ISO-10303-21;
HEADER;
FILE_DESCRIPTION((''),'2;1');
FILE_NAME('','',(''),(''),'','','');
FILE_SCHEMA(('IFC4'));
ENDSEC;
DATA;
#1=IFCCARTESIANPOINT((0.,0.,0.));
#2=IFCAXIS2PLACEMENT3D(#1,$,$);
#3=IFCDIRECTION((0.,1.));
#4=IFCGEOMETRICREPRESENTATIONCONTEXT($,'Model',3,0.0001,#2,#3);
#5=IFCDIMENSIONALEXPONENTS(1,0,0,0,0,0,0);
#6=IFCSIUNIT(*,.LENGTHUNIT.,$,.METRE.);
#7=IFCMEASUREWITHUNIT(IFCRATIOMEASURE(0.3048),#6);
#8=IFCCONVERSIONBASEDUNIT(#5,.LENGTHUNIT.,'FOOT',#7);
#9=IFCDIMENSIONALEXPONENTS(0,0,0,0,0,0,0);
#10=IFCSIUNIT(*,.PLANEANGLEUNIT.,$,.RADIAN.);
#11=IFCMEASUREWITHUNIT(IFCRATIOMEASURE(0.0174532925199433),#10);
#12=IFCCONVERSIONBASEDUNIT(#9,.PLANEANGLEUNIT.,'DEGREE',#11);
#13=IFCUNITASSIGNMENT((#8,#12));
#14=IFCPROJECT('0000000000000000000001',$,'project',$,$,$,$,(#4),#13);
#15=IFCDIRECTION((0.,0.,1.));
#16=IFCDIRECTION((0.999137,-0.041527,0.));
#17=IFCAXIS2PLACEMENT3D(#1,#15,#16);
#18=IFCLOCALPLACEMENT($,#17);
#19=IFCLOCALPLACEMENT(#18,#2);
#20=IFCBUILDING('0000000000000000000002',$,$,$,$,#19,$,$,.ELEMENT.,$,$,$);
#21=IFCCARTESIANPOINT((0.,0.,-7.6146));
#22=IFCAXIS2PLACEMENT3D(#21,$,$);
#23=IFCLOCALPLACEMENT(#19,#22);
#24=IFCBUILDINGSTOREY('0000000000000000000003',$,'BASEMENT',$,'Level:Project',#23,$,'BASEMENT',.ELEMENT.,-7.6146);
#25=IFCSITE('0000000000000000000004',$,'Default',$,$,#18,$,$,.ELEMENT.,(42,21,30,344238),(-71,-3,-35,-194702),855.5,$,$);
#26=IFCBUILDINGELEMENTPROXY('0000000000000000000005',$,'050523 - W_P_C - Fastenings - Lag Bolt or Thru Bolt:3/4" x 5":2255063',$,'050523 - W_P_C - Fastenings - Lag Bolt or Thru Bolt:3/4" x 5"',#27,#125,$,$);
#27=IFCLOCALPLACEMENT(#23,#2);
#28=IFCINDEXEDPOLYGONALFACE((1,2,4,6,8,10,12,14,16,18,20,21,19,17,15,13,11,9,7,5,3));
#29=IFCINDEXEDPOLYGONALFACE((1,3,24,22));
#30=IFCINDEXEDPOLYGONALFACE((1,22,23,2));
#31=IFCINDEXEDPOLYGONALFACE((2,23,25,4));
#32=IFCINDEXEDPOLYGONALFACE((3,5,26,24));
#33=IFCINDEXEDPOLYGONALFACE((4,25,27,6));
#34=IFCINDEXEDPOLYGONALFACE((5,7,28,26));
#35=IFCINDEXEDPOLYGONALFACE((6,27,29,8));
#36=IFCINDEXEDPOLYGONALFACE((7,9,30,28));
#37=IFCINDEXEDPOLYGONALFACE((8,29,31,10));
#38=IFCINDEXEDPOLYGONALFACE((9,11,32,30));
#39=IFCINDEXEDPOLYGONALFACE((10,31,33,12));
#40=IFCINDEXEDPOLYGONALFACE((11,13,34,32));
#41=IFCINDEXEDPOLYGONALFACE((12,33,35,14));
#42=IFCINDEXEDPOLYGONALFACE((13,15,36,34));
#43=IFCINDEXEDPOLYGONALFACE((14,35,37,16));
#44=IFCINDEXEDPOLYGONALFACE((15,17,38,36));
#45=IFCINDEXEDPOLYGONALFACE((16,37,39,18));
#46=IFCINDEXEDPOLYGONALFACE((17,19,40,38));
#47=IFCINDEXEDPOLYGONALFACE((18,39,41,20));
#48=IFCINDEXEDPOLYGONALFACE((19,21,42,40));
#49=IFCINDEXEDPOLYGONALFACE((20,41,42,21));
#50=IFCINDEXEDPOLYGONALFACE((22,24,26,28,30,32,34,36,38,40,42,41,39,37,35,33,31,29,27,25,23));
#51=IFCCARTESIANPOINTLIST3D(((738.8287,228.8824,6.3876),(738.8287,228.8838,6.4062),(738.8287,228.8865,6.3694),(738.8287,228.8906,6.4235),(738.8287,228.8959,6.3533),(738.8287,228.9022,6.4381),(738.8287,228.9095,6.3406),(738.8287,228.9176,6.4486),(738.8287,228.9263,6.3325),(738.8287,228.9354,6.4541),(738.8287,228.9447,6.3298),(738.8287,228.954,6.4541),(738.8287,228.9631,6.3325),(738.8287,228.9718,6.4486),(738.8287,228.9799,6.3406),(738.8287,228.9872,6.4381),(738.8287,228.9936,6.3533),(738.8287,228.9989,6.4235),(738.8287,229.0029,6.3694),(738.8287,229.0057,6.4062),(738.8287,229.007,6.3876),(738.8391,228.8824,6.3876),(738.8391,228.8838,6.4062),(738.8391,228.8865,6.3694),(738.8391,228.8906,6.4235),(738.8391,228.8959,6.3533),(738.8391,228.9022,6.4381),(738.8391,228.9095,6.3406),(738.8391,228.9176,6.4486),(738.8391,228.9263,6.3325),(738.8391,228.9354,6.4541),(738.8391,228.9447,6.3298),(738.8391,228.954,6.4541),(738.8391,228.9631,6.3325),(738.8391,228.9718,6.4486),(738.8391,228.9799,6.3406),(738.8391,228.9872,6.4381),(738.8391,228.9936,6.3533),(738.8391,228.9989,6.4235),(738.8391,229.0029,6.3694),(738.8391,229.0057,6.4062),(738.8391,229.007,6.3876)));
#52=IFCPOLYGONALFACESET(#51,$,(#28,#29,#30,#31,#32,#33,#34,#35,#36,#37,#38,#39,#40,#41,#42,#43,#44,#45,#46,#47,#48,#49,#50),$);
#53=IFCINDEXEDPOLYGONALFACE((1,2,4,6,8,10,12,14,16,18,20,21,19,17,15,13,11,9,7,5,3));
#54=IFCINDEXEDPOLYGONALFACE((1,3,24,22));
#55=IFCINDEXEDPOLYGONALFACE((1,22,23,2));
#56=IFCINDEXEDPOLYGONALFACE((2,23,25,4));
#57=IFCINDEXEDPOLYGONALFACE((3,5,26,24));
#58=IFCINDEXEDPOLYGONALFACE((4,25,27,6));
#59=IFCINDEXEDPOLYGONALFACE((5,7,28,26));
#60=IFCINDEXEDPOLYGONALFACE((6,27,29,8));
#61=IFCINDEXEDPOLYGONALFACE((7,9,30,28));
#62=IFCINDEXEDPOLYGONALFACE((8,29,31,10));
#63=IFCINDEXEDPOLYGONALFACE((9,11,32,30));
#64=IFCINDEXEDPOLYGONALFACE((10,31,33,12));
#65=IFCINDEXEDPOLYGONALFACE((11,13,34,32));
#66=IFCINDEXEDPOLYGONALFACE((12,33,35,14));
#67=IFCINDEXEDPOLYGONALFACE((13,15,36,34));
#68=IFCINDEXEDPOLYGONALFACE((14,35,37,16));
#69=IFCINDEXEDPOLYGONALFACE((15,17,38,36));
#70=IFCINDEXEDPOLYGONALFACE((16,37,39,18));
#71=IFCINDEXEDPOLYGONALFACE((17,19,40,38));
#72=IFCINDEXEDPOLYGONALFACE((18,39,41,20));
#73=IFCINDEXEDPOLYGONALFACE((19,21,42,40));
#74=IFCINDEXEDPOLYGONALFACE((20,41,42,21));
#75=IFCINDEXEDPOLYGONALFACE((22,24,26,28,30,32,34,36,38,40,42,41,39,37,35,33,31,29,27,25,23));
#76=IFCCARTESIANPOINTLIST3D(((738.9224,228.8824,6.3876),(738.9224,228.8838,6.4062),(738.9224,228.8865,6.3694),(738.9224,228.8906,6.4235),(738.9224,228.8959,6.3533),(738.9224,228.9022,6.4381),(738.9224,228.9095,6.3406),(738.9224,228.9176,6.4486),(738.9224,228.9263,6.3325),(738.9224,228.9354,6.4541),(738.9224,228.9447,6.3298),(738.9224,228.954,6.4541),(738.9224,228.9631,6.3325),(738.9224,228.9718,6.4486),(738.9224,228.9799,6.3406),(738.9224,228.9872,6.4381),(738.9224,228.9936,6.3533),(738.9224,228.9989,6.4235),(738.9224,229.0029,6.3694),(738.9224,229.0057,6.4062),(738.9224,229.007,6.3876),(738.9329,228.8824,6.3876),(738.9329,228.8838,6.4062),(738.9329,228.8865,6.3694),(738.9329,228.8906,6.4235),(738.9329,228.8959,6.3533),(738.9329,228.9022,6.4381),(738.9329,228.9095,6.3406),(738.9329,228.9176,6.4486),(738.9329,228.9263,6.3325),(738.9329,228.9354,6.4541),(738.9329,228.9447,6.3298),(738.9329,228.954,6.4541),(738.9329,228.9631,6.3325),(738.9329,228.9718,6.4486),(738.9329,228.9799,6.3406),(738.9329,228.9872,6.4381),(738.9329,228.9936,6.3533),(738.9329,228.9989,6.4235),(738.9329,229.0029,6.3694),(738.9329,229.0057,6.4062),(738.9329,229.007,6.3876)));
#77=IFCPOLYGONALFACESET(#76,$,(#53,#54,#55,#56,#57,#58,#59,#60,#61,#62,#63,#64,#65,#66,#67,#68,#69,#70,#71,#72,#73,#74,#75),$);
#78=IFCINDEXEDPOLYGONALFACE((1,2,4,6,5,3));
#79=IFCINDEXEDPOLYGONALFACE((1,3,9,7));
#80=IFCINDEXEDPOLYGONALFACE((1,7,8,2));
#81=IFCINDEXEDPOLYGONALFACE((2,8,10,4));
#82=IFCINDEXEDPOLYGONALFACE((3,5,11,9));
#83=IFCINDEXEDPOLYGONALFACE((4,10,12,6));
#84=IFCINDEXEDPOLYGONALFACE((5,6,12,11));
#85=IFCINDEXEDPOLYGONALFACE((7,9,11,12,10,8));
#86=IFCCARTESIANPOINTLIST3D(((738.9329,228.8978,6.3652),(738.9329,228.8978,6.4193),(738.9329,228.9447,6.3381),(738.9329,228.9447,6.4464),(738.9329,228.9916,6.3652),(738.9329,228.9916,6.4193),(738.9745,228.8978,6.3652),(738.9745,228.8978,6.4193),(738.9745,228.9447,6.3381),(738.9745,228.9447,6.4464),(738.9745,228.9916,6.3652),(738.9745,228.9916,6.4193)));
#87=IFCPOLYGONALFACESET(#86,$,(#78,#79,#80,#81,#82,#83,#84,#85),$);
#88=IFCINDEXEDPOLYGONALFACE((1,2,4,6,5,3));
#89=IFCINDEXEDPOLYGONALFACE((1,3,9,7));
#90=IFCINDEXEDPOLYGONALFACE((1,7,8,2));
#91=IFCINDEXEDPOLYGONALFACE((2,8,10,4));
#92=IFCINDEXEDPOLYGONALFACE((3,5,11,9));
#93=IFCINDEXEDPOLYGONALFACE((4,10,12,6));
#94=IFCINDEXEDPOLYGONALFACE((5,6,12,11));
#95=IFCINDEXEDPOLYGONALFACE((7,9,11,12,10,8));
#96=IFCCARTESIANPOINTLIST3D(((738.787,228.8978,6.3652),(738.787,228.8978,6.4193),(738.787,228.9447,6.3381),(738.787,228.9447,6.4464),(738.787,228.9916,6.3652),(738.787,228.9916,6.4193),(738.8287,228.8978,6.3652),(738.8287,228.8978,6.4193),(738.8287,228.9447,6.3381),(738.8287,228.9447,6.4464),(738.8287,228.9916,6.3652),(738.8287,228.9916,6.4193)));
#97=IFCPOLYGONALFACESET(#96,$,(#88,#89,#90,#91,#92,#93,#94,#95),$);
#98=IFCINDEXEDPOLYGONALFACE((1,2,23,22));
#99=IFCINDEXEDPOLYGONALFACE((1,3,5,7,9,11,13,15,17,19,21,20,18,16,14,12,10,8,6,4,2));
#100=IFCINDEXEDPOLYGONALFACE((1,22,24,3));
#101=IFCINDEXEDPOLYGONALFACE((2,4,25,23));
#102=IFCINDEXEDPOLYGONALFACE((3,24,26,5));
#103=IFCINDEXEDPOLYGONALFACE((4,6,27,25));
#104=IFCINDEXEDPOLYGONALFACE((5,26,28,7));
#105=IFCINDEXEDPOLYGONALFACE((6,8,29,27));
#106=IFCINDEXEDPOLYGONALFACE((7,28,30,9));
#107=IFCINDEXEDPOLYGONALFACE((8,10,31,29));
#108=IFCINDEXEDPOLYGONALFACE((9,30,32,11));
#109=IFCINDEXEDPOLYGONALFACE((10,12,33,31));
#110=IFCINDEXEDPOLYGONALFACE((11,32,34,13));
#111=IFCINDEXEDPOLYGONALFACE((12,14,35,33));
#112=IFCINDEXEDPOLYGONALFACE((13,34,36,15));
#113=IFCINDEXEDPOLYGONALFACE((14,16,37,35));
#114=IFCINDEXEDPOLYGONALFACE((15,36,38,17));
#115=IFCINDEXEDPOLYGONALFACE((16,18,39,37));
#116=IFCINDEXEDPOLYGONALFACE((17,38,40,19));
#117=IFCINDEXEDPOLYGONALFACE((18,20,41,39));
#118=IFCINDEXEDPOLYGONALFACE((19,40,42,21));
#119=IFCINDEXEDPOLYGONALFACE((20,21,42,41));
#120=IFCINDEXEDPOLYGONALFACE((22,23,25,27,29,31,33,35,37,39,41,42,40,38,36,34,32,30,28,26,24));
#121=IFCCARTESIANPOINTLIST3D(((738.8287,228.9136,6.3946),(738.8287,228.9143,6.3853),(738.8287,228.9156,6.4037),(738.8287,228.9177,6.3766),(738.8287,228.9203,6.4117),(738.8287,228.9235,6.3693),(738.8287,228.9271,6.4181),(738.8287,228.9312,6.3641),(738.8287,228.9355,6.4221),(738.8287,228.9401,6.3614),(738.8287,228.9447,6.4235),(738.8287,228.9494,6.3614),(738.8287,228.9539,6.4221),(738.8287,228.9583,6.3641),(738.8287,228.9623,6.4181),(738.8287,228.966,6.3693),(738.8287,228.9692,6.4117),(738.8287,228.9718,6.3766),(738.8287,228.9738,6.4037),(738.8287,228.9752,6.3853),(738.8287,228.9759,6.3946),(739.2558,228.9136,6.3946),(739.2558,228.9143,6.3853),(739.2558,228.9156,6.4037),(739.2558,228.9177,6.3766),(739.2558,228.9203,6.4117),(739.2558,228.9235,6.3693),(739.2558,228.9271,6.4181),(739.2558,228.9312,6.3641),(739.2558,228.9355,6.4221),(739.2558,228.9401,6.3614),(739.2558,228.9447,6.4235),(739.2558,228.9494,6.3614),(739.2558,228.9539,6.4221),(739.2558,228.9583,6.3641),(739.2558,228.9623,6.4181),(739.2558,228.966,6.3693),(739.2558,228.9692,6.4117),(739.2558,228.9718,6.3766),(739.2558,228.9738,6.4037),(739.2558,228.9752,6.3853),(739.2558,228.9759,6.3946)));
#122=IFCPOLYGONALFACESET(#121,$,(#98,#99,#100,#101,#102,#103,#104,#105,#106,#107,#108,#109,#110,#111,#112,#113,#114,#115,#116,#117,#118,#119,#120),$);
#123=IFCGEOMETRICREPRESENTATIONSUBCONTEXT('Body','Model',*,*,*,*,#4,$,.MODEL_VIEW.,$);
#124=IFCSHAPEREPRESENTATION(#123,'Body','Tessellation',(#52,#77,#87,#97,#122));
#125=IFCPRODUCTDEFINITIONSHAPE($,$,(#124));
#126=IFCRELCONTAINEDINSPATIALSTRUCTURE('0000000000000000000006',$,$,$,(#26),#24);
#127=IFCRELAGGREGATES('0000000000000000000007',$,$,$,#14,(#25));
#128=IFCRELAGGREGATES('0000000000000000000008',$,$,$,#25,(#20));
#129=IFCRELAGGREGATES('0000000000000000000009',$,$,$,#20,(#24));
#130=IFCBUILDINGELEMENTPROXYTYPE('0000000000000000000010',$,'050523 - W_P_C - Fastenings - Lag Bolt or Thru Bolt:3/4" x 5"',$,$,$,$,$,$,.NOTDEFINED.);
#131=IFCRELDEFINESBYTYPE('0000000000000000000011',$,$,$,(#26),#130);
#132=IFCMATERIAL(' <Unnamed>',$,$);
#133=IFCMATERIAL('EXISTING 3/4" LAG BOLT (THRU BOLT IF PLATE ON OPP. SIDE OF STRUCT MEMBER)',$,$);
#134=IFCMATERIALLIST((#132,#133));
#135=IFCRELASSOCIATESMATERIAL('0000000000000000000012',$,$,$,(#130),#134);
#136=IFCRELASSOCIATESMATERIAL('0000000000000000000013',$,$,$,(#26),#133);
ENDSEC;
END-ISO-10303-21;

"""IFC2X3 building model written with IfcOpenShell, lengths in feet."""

from ifc_helpers import new_model, entity, si_unit, converted_unit, direction, frame, frame_2d, origin, place, context, subcontext, project, spatial, polyline, circle, outline, extrude, source, transform, mapped, material, material_list, type_object, type_shapes, element, save


model = new_model("IFC2X3")

# Units and contexts
model_context = context("Model", 3, precision=0.0001, world=origin(), true_north=direction((0.0, 1.0)))
body_context = subcontext(model_context, "Body", "Model", "MODEL_VIEW")
ifc_project = project(units=[converted_unit("LENGTHUNIT", "FOOT", entity("IfcRatioMeasure", 0.3048), si_unit("LENGTHUNIT", "METRE"), dimensions=[1, 0, 0, 0, 0, 0, 0]), converted_unit("PLANEANGLEUNIT", "DEGREE", entity("IfcRatioMeasure", 0.0174532925199433), si_unit("PLANEANGLEUNIT", "RADIAN"), dimensions=[0, 0, 0, 0, 0, 0, 0])], contexts=[model_context])

# Site, building, storey
site_placement = place(None, frame((0.0, 0.0, 0.0), z_axis=(0.0, 0.0, 1.0), x_axis=(0.999137, -0.041527, 0.0)))
site = spatial("IfcSite", under=ifc_project, at=site_placement, Name="Default", CompositionType="ELEMENT", RefLatitude=(42, 21, 30, 344238), RefLongitude=(-71, -3, -35, -194702), RefElevation=855.5)
building_placement = place(site_placement, origin())
building = spatial("IfcBuilding", under=site, at=building_placement, CompositionType="ELEMENT")
storey_placement = place(building_placement, frame((0.0, 0.0, -7.6146)))
storey = spatial("IfcBuildingStorey", under=building, at=storey_placement, Name="BASEMENT", ObjectType="Level:Project", LongName="BASEMENT", CompositionType="ELEMENT", Elevation=-7.6146)

# Building element proxy
ifc_material_1 = material(Name="EXISTING 3/4\" LAG BOLT (THRU BOLT IF PLATE ON OPP. SIDE OF STRUCT MEMBER)")
ifc_material_2 = material(Name=" <Unnamed>")
ifc_material_list_1 = material_list([ifc_material_2, ifc_material_1])
building_element_proxy_type_1 = type_object("IfcBuildingElementProxyType", Name="050523 - W_P_C - Fastenings - Lag Bolt or Thru Bolt:3/4\" x 5\"", PredefinedType="NOTDEFINED", material=ifc_material_list_1)
shared_shape_1 = source(origin(), body_context, "Body", "SweptSolid", [
    extrude(circle(Radius=0.0625, at=frame_2d((0.0, 0.0), x_axis=(1.0, 0.0))), frame((0.0, 0.0, 0.0), z_axis=(0.0, 0.0, 1.0), x_axis=(0.0, -1.0, 0.0)), (0.0, 0.0, 1.0), 0.0104),
    extrude(circle(Radius=0.0625, at=frame_2d((0.0, 0.0), x_axis=(1.0, 0.0))), frame((0.0, 0.0, -0.0938), z_axis=(0.0, 0.0, 1.0), x_axis=(0.0, -1.0, 0.0)), (0.0, 0.0, 1.0), 0.0104),
    extrude(outline(polyline([(-0.0271, -0.0469), (0.0271, -0.0469), (0.0541, 0.0), (0.0271, 0.0469), (-0.0271, 0.0469), (-0.0541, 0.0), (-0.0271, -0.0469)])), frame((0.0, 0.0, -0.1354), z_axis=(0.0, 0.0, 1.0), x_axis=(0.866025, -0.5, 0.0)), (0.0, 0.0, 1.0), 0.0417),
    extrude(outline(polyline([(-0.0271, -0.0469), (0.0271, -0.0469), (0.0541, 0.0), (0.0271, 0.0469), (-0.0271, 0.0469), (-0.0541, 0.0), (-0.0271, -0.0469)])), frame((0.0, 0.0, 0.0104), z_axis=(0.0, 0.0, 1.0), x_axis=(0.0, -1.0, 0.0)), (0.0, 0.0, 1.0), 0.0417),
    extrude(circle(Radius=0.0312, at=frame_2d((0.0, 0.0), x_axis=(1.0, 0.0))), frame((0.0, 0.0, -0.4167), z_axis=(0.0, 0.0, 1.0), x_axis=(0.0, 1.0, 0.0)), (0.0, 0.0, 1.0), 0.4271),
])
type_shapes(building_element_proxy_type_1, [shared_shape_1])
for number, where, z_axis, x_axis, name in (
    (1, (738.8391, 228.9447, 6.3923), (-1.0, 0.0, 0.0), (0.0, -1.0, 0.0), "050523 - W_P_C - Fastenings - Lag Bolt or Thru Bolt:3/4\" x 5\":2255063"),
):
    element("IfcBuildingElementProxy", number, at=place(storey_placement, frame(where, z_axis=z_axis, x_axis=x_axis)), inside=storey, type_object=building_element_proxy_type_1, material=ifc_material_1, Name=name, ObjectType="050523 - W_P_C - Fastenings - Lag Bolt or Thru Bolt:3/4\" x 5\"", context=body_context, shape_type="MappedRepresentation", body=[
        mapped(shared_shape_1, transform((0.0, 0.0, 0.0), scale=1.0)),
    ])

save(model, "model.ifc")
